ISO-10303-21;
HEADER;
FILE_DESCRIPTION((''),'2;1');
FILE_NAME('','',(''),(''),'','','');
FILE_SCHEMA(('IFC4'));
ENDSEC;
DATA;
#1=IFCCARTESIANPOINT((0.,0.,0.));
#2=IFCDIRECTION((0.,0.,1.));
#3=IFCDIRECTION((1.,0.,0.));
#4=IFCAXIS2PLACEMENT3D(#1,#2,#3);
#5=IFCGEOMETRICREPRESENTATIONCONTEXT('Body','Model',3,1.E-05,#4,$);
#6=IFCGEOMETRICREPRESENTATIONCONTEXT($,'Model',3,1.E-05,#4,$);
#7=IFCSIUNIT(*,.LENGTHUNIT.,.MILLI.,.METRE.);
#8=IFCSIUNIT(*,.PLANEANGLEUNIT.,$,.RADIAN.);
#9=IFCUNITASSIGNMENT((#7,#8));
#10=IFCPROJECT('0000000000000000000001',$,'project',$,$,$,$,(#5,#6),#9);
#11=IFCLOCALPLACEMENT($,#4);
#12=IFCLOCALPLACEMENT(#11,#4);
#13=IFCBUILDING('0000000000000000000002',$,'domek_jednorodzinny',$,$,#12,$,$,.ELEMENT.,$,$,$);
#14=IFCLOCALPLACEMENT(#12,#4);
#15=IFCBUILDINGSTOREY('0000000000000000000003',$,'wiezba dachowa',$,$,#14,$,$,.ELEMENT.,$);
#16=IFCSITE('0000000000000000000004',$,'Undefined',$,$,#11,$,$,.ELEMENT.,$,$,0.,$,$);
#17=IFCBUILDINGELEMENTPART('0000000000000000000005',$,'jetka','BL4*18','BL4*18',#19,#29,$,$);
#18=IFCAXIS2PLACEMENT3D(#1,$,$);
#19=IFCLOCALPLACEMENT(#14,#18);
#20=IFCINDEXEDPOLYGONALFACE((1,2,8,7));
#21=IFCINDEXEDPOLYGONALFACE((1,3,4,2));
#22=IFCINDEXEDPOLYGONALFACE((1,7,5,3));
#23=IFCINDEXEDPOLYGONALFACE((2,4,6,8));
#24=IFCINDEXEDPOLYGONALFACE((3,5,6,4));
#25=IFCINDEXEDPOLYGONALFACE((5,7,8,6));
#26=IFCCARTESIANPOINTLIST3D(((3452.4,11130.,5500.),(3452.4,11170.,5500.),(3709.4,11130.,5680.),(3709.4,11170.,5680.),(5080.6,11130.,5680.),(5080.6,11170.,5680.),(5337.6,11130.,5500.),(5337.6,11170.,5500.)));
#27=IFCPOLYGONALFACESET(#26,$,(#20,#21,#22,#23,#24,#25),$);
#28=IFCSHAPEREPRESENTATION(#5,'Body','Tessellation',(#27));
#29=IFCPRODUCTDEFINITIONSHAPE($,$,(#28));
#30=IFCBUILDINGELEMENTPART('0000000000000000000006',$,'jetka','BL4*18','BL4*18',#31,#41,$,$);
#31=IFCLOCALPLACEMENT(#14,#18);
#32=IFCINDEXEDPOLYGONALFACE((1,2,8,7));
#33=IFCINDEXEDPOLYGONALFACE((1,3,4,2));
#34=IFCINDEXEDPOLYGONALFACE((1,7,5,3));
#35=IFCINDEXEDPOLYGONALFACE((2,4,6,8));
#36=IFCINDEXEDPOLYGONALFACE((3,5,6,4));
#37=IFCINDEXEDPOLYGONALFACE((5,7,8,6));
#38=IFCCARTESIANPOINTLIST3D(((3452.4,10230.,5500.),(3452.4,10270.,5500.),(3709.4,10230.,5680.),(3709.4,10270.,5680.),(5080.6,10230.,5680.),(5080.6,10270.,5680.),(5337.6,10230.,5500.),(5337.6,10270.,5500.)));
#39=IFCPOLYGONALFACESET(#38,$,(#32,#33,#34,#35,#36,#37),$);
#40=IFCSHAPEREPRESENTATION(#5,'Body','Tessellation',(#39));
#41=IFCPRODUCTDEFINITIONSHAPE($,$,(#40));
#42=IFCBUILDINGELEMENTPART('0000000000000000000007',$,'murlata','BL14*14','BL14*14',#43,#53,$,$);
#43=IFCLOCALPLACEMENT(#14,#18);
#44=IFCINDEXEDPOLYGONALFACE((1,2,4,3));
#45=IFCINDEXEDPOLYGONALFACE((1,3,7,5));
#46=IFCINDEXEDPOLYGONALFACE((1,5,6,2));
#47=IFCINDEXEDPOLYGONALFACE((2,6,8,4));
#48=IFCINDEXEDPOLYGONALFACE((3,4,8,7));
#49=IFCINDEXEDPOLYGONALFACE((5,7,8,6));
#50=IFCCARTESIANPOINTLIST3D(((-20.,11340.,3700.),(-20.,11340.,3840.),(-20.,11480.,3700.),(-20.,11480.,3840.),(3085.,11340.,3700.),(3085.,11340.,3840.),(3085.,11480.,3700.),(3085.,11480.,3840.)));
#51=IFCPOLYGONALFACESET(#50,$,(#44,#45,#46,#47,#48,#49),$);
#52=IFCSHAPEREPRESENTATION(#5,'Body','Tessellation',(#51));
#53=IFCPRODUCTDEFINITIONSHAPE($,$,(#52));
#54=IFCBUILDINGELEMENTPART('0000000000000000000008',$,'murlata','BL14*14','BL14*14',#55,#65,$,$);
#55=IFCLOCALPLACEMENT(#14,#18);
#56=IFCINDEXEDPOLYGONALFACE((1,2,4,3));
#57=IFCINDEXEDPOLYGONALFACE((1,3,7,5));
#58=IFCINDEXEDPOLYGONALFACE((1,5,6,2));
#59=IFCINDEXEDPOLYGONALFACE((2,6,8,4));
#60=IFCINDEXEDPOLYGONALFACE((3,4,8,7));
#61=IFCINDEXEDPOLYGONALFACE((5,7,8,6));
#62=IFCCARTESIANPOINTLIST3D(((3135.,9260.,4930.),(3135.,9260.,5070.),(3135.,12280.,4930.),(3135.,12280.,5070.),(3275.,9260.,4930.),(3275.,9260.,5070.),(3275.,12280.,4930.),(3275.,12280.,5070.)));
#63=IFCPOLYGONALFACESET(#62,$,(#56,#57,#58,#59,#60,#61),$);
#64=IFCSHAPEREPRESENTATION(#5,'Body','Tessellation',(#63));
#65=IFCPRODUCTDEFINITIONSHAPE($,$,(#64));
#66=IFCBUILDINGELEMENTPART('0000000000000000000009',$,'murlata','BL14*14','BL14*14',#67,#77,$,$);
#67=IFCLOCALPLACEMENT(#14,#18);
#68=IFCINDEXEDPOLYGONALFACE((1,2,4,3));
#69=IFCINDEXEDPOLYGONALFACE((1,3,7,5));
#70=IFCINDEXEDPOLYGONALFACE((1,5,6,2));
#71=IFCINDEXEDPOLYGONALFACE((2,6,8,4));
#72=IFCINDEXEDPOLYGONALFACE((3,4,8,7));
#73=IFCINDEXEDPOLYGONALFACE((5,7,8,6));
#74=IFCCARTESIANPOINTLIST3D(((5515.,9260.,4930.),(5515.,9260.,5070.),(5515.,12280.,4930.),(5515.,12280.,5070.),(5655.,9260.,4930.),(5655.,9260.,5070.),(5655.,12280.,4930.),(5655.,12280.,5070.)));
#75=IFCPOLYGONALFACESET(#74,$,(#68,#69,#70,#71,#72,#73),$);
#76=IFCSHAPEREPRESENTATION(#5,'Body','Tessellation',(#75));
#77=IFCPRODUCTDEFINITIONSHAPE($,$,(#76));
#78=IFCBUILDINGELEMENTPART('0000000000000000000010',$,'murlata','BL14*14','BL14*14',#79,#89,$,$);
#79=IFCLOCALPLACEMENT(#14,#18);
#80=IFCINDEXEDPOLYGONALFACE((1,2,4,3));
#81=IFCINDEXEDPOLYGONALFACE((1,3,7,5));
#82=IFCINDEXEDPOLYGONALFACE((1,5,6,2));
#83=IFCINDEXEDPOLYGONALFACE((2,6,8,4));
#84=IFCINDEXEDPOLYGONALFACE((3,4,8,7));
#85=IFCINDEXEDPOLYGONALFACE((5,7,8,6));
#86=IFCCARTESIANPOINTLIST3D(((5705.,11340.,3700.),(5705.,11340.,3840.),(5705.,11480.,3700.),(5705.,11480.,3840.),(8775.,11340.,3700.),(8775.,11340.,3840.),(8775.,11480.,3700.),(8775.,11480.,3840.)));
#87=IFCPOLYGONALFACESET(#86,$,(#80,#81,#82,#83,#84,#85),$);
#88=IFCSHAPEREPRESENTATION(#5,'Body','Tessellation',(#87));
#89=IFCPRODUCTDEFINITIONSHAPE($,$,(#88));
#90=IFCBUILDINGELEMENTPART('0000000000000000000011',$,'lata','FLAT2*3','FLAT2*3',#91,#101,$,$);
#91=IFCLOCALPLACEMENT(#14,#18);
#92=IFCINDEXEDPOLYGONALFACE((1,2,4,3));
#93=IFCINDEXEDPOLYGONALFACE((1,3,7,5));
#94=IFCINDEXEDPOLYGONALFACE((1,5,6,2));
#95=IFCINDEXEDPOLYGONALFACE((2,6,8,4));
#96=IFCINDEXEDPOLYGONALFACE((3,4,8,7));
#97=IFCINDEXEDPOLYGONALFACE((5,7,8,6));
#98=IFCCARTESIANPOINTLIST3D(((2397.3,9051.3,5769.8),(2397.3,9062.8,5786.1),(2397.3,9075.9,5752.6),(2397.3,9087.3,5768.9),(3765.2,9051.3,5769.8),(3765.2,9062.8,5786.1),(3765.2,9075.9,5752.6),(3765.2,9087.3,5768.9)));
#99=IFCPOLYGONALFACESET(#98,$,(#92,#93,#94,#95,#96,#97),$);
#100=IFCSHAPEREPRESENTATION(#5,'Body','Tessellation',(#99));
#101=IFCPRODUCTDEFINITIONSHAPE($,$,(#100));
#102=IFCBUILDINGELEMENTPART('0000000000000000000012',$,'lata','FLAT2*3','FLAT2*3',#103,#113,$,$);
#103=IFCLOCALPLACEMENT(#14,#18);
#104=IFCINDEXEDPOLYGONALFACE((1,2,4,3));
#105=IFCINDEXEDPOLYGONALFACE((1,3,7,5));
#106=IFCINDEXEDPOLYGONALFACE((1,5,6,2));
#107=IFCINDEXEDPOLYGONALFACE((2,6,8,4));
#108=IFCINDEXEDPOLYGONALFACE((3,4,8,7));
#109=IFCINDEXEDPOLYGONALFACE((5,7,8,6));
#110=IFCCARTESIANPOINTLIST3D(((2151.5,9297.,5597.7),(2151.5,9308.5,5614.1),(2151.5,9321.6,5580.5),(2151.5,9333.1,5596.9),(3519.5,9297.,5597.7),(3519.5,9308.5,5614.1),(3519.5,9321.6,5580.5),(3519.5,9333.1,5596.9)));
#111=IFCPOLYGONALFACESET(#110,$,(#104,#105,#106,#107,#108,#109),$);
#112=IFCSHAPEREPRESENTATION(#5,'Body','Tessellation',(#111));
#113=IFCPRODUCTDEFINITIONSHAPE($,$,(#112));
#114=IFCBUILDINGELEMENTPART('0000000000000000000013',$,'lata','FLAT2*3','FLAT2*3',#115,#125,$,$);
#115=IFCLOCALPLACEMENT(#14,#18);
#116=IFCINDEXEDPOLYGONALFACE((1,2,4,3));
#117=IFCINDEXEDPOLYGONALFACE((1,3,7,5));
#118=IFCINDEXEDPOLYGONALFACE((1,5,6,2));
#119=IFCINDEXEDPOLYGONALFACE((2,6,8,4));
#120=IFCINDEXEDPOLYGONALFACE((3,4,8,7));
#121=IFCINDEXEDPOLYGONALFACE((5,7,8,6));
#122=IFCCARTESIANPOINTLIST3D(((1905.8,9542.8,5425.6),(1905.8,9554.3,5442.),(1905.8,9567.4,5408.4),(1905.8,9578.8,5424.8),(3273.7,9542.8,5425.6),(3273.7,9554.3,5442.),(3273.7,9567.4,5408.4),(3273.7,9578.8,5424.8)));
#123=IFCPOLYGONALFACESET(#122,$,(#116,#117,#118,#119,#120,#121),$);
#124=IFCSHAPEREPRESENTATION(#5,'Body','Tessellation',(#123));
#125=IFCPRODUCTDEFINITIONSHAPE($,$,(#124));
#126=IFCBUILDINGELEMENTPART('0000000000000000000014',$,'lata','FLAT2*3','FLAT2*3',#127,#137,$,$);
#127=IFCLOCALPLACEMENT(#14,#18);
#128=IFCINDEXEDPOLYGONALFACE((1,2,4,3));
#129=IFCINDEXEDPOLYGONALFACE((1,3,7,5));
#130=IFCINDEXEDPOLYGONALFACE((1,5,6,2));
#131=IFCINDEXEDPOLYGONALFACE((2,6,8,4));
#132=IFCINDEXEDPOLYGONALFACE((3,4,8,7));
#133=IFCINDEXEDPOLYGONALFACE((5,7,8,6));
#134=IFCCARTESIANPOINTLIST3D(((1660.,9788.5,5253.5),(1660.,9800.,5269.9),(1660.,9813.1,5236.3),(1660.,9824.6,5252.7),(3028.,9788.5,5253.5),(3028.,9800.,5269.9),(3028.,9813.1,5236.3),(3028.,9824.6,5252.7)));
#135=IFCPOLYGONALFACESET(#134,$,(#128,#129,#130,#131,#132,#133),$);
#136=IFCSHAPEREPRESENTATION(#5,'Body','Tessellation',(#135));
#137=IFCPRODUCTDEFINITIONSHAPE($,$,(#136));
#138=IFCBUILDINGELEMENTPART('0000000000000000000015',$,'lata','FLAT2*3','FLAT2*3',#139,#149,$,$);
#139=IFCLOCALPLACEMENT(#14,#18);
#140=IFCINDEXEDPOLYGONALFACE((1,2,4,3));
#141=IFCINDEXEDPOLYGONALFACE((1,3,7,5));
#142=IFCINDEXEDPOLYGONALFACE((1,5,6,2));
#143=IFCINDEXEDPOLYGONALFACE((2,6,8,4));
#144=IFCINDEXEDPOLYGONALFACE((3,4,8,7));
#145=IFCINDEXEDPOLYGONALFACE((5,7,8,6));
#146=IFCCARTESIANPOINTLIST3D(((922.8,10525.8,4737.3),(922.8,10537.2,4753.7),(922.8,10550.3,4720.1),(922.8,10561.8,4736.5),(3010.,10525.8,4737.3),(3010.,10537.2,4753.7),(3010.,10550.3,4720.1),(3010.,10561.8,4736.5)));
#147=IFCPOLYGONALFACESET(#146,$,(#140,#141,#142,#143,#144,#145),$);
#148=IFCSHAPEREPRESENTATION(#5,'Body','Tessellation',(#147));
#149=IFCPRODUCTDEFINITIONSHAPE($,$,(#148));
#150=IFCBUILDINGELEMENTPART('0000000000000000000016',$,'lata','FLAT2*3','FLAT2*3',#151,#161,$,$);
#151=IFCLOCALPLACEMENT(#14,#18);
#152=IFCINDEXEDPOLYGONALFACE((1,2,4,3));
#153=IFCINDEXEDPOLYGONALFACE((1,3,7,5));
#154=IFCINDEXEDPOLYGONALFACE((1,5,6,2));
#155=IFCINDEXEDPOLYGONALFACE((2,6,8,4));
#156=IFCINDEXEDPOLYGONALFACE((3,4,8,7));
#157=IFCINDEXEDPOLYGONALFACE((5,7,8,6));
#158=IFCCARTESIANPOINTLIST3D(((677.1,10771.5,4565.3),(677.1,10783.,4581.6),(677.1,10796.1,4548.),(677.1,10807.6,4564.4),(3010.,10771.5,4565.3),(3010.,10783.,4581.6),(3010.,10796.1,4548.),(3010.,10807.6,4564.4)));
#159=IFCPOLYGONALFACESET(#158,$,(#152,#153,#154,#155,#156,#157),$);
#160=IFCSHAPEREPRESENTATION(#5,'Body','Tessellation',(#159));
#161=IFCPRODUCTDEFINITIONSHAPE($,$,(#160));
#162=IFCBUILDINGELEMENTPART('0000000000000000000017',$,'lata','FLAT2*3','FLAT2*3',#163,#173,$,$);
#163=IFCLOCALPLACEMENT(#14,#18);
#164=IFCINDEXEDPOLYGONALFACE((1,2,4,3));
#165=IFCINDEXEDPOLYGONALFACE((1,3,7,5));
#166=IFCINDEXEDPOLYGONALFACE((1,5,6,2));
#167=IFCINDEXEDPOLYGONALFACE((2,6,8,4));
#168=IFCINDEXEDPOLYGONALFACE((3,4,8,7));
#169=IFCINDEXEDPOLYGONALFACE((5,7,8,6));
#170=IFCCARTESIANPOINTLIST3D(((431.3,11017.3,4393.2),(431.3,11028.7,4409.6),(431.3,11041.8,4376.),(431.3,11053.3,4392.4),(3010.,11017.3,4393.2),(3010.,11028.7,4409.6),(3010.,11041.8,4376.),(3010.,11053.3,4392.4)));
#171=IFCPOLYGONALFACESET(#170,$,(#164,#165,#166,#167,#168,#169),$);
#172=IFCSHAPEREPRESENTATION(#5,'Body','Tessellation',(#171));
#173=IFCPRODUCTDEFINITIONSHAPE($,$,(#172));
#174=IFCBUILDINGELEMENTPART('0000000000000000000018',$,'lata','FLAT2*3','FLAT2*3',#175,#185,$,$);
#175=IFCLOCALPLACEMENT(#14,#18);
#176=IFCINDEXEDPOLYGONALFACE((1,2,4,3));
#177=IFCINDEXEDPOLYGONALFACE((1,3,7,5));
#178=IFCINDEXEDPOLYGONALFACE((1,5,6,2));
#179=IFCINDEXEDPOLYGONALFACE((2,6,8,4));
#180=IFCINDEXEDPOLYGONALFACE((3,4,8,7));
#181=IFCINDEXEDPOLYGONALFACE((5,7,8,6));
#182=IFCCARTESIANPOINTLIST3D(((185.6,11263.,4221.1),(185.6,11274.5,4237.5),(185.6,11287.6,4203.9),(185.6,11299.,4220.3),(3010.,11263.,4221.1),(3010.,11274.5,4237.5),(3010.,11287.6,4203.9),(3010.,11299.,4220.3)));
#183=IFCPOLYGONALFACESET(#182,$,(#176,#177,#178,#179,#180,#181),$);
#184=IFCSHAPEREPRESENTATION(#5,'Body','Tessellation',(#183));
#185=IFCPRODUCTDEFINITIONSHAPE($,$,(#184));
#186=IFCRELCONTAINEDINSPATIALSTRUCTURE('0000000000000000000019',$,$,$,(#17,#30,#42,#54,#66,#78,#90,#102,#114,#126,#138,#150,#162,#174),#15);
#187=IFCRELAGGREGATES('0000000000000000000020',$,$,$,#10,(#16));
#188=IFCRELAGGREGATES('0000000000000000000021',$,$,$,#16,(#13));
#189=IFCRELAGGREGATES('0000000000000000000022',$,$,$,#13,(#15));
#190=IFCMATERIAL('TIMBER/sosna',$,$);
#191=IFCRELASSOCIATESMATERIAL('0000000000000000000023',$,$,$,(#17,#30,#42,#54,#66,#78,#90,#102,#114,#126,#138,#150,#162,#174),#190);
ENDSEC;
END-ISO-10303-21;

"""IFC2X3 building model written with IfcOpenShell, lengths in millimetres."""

from ifc_helpers import new_model, si_unit, frame, origin_with_axes, origin_2d_with_axis, place, context, project, spatial, rectangle, extrude, clip, halfspace, material, element, save


model = new_model("IFC2X3")

# Units and contexts
model_context_1 = context("Model", 3, precision=1e-05, world=origin_with_axes(), identifier="Body")
model_context_2 = context("Model", 3, precision=1e-05, world=origin_with_axes())
ifc_project = project(units=[si_unit("LENGTHUNIT", "METRE", prefix="MILLI"), si_unit("PLANEANGLEUNIT", "RADIAN")], contexts=[model_context_1, model_context_2])

# Site, building, storey
site_placement = place(None, origin_with_axes())
site = spatial("IfcSite", under=ifc_project, at=site_placement, Name="Undefined", CompositionType="ELEMENT", RefElevation=0.0)
building_placement = place(site_placement, origin_with_axes())
building = spatial("IfcBuilding", under=site, at=building_placement, Name="domek_jednorodzinny", CompositionType="ELEMENT")
storey_placement = place(building_placement, origin_with_axes())
storey = spatial("IfcBuildingStorey", under=building, at=storey_placement, Name="wiezba dachowa", CompositionType="ELEMENT")

# Building element parts
ifc_material = material(Name="TIMBER/sosna")
building_element_part_1_placement = place(storey_placement, frame((3452.4, 11150.0, 5590.0), z_axis=(0.0, 0.0, 1.0), x_axis=(1.0, 0.0, 0.0)))
element("IfcBuildingElementPart", 1, at=building_element_part_1_placement, inside=storey, material=ifc_material, Name="jetka", Description="BL4*18", ObjectType="BL4*18", context=model_context_1, shape_type="Clipping", body=[
    clip(clip(extrude(rectangle(XDim=40.0, YDim=180.0, at=origin_2d_with_axis()), frame((1885.2, 0.0, 0.0), z_axis=(-1.0, 0.0, 0.0), x_axis=(0.0, -1.0, 0.0)), (0.0, 0.0, 1.0), 1885.2), halfspace(frame((1885.2, 40.0, -90.0), z_axis=(0.573578, 0.0, 0.819151), x_axis=(0.0, -1.0, 0.0)), False)), halfspace(frame((0.0, -40.0, -90.0), z_axis=(-0.573576, 0.0, 0.819152), x_axis=(0.0, 1.0, 0.0)), False)),
])
building_element_part_2_placement = place(storey_placement, frame((3452.4, 10250.0, 5590.0), z_axis=(0.0, 0.0, 1.0), x_axis=(1.0, 0.0, 0.0)))
element("IfcBuildingElementPart", 2, at=building_element_part_2_placement, inside=storey, material=ifc_material, Name="jetka", Description="BL4*18", ObjectType="BL4*18", context=model_context_1, shape_type="Clipping", body=[
    clip(clip(extrude(rectangle(XDim=40.0, YDim=180.0, at=origin_2d_with_axis()), frame((1885.2, 0.0, 0.0), z_axis=(-1.0, 0.0, 0.0), x_axis=(0.0, -1.0, 0.0)), (0.0, 0.0, 1.0), 1885.2), halfspace(frame((1885.2, 40.0, -90.0), z_axis=(0.573578, 0.0, 0.819151), x_axis=(0.0, -1.0, 0.0)), False)), halfspace(frame((0.0, -40.0, -90.0), z_axis=(-0.573576, 0.0, 0.819152), x_axis=(0.0, 1.0, 0.0)), False)),
])
building_element_part_3_placement = place(storey_placement, frame((3085.0, 11410.0, 3770.0), z_axis=(0.0, 0.0, 1.0), x_axis=(-1.0, 0.0, 0.0)))
element("IfcBuildingElementPart", 3, at=building_element_part_3_placement, inside=storey, material=ifc_material, Name="murlata", Description="BL14*14", ObjectType="BL14*14", context=model_context_1, shape_type="SweptSolid", body=[
    extrude(rectangle(XDim=140.0, YDim=140.0, at=origin_2d_with_axis()), frame((3105.0, 0.0, 0.0), z_axis=(-1.0, 0.0, 0.0), x_axis=(0.0, -1.0, 0.0)), (0.0, 0.0, 1.0), 3105.0),
])
for number, where, z_axis, x_axis, name in (
    (4, (3205.0, 9260.0, 5000.0), (0.0, 0.0, 1.0), (0.0, 1.0, 0.0), "murlata"),
    (5, (5585.0, 9260.0, 5000.0), (0.0, 0.0, 1.0), (0.0, 1.0, 0.0), "murlata"),
):
    element("IfcBuildingElementPart", number, at=place(storey_placement, frame(where, z_axis=z_axis, x_axis=x_axis)), inside=storey, material=ifc_material, Name=name, Description="BL14*14", ObjectType="BL14*14", context=model_context_1, shape_type="SweptSolid", body=[
        extrude(rectangle(XDim=140.0, YDim=140.0, at=origin_2d_with_axis()), frame((3020.0, 0.0, 0.0), z_axis=(-1.0, 0.0, 0.0), x_axis=(0.0, -1.0, 0.0)), (0.0, 0.0, 1.0), 3020.0),
    ])
building_element_part_4_placement = place(storey_placement, frame((5705.0, 11410.0, 3770.0), z_axis=(0.0, 0.0, 1.0), x_axis=(1.0, 0.0, 0.0)))
element("IfcBuildingElementPart", 6, at=building_element_part_4_placement, inside=storey, material=ifc_material, Name="murlata", Description="BL14*14", ObjectType="BL14*14", context=model_context_1, shape_type="SweptSolid", body=[
    extrude(rectangle(XDim=140.0, YDim=140.0, at=origin_2d_with_axis()), frame((3070.0, 0.0, 0.0), z_axis=(-1.0, 0.0, 0.0), x_axis=(0.0, -1.0, 0.0)), (0.0, 0.0, 1.0), 3070.0),
])
building_element_part_5_placement = place(storey_placement, frame((3765.2, 9069.3, 5769.4), z_axis=(0.0, -0.819154, 0.573574), x_axis=(-1.0, 0.0, 0.0)))
element("IfcBuildingElementPart", 7, at=building_element_part_5_placement, inside=storey, material=ifc_material, Name="lata", Description="FLAT2*3", ObjectType="FLAT2*3", context=model_context_1, shape_type="SweptSolid", body=[
    extrude(rectangle(XDim=20.0, YDim=30.0, at=origin_2d_with_axis()), frame((1368.0, 0.0, 0.0), z_axis=(-1.0, 0.0, 0.0), x_axis=(0.0, -1.0, 0.0)), (0.0, 0.0, 1.0), 1368.0),
])
building_element_part_6_placement = place(storey_placement, frame((3519.5, 9315.1, 5597.3), z_axis=(0.0, -0.819154, 0.573574), x_axis=(-1.0, 0.0, 0.0)))
element("IfcBuildingElementPart", 8, at=building_element_part_6_placement, inside=storey, material=ifc_material, Name="lata", Description="FLAT2*3", ObjectType="FLAT2*3", context=model_context_1, shape_type="SweptSolid", body=[
    extrude(rectangle(XDim=20.0, YDim=30.0, at=origin_2d_with_axis()), frame((1368.0, 0.0, 0.0), z_axis=(-1.0, 0.0, 0.0), x_axis=(0.0, -1.0, 0.0)), (0.0, 0.0, 1.0), 1368.0),
])
building_element_part_7_placement = place(storey_placement, frame((3273.7, 9560.8, 5425.2), z_axis=(0.0, -0.819154, 0.573574), x_axis=(-1.0, 0.0, 0.0)))
element("IfcBuildingElementPart", 9, at=building_element_part_7_placement, inside=storey, material=ifc_material, Name="lata", Description="FLAT2*3", ObjectType="FLAT2*3", context=model_context_1, shape_type="SweptSolid", body=[
    extrude(rectangle(XDim=20.0, YDim=30.0, at=origin_2d_with_axis()), frame((1368.0, 0.0, 0.0), z_axis=(-1.0, 0.0, 0.0), x_axis=(0.0, -1.0, 0.0)), (0.0, 0.0, 1.0), 1368.0),
])
building_element_part_8_placement = place(storey_placement, frame((3028.0, 9806.6, 5253.1), z_axis=(0.0, -0.819154, 0.573574), x_axis=(-1.0, 0.0, 0.0)))
element("IfcBuildingElementPart", 10, at=building_element_part_8_placement, inside=storey, material=ifc_material, Name="lata", Description="FLAT2*3", ObjectType="FLAT2*3", context=model_context_1, shape_type="SweptSolid", body=[
    extrude(rectangle(XDim=20.0, YDim=30.0, at=origin_2d_with_axis()), frame((1368.0, 0.0, 0.0), z_axis=(-1.0, 0.0, 0.0), x_axis=(0.0, -1.0, 0.0)), (0.0, 0.0, 1.0), 1368.0),
])
building_element_part_9_placement = place(storey_placement, frame((3010.0, 10543.8, 4736.9), z_axis=(0.0, -0.819154, 0.573574), x_axis=(-1.0, 0.0, 0.0)))
element("IfcBuildingElementPart", 11, at=building_element_part_9_placement, inside=storey, material=ifc_material, Name="lata", Description="FLAT2*3", ObjectType="FLAT2*3", context=model_context_1, shape_type="SweptSolid", body=[
    extrude(rectangle(XDim=20.0, YDim=30.0, at=origin_2d_with_axis()), frame((2087.2, 0.0, 0.0), z_axis=(-1.0, 0.0, 0.0), x_axis=(0.0, -1.0, 0.0)), (0.0, 0.0, 1.0), 2087.2),
])
building_element_part_10_placement = place(storey_placement, frame((3010.0, 10789.5, 4564.8), z_axis=(0.0, -0.819154, 0.573574), x_axis=(-1.0, 0.0, 0.0)))
element("IfcBuildingElementPart", 12, at=building_element_part_10_placement, inside=storey, material=ifc_material, Name="lata", Description="FLAT2*3", ObjectType="FLAT2*3", context=model_context_1, shape_type="SweptSolid", body=[
    extrude(rectangle(XDim=20.0, YDim=30.0, at=origin_2d_with_axis()), frame((2333.0, 0.0, 0.0), z_axis=(-1.0, 0.0, 0.0), x_axis=(0.0, -1.0, 0.0)), (0.0, 0.0, 1.0), 2333.0),
])
building_element_part_11_placement = place(storey_placement, frame((3010.0, 11035.3, 4392.8), z_axis=(0.0, -0.819154, 0.573574), x_axis=(-1.0, 0.0, 0.0)))
element("IfcBuildingElementPart", 13, at=building_element_part_11_placement, inside=storey, material=ifc_material, Name="lata", Description="FLAT2*3", ObjectType="FLAT2*3", context=model_context_1, shape_type="SweptSolid", body=[
    extrude(rectangle(XDim=20.0, YDim=30.0, at=origin_2d_with_axis()), frame((2578.7, 0.0, 0.0), z_axis=(-1.0, 0.0, 0.0), x_axis=(0.0, -1.0, 0.0)), (0.0, 0.0, 1.0), 2578.7),
])
building_element_part_12_placement = place(storey_placement, frame((3010.0, 11281.0, 4220.7), z_axis=(0.0, -0.819154, 0.573574), x_axis=(-1.0, 0.0, 0.0)))
element("IfcBuildingElementPart", 14, at=building_element_part_12_placement, inside=storey, material=ifc_material, Name="lata", Description="FLAT2*3", ObjectType="FLAT2*3", context=model_context_1, shape_type="SweptSolid", body=[
    extrude(rectangle(XDim=20.0, YDim=30.0, at=origin_2d_with_axis()), frame((2824.5, 0.0, 0.0), z_axis=(-1.0, 0.0, 0.0), x_axis=(0.0, -1.0, 0.0)), (0.0, 0.0, 1.0), 2824.5),
])

save(model, "model.ifc")
